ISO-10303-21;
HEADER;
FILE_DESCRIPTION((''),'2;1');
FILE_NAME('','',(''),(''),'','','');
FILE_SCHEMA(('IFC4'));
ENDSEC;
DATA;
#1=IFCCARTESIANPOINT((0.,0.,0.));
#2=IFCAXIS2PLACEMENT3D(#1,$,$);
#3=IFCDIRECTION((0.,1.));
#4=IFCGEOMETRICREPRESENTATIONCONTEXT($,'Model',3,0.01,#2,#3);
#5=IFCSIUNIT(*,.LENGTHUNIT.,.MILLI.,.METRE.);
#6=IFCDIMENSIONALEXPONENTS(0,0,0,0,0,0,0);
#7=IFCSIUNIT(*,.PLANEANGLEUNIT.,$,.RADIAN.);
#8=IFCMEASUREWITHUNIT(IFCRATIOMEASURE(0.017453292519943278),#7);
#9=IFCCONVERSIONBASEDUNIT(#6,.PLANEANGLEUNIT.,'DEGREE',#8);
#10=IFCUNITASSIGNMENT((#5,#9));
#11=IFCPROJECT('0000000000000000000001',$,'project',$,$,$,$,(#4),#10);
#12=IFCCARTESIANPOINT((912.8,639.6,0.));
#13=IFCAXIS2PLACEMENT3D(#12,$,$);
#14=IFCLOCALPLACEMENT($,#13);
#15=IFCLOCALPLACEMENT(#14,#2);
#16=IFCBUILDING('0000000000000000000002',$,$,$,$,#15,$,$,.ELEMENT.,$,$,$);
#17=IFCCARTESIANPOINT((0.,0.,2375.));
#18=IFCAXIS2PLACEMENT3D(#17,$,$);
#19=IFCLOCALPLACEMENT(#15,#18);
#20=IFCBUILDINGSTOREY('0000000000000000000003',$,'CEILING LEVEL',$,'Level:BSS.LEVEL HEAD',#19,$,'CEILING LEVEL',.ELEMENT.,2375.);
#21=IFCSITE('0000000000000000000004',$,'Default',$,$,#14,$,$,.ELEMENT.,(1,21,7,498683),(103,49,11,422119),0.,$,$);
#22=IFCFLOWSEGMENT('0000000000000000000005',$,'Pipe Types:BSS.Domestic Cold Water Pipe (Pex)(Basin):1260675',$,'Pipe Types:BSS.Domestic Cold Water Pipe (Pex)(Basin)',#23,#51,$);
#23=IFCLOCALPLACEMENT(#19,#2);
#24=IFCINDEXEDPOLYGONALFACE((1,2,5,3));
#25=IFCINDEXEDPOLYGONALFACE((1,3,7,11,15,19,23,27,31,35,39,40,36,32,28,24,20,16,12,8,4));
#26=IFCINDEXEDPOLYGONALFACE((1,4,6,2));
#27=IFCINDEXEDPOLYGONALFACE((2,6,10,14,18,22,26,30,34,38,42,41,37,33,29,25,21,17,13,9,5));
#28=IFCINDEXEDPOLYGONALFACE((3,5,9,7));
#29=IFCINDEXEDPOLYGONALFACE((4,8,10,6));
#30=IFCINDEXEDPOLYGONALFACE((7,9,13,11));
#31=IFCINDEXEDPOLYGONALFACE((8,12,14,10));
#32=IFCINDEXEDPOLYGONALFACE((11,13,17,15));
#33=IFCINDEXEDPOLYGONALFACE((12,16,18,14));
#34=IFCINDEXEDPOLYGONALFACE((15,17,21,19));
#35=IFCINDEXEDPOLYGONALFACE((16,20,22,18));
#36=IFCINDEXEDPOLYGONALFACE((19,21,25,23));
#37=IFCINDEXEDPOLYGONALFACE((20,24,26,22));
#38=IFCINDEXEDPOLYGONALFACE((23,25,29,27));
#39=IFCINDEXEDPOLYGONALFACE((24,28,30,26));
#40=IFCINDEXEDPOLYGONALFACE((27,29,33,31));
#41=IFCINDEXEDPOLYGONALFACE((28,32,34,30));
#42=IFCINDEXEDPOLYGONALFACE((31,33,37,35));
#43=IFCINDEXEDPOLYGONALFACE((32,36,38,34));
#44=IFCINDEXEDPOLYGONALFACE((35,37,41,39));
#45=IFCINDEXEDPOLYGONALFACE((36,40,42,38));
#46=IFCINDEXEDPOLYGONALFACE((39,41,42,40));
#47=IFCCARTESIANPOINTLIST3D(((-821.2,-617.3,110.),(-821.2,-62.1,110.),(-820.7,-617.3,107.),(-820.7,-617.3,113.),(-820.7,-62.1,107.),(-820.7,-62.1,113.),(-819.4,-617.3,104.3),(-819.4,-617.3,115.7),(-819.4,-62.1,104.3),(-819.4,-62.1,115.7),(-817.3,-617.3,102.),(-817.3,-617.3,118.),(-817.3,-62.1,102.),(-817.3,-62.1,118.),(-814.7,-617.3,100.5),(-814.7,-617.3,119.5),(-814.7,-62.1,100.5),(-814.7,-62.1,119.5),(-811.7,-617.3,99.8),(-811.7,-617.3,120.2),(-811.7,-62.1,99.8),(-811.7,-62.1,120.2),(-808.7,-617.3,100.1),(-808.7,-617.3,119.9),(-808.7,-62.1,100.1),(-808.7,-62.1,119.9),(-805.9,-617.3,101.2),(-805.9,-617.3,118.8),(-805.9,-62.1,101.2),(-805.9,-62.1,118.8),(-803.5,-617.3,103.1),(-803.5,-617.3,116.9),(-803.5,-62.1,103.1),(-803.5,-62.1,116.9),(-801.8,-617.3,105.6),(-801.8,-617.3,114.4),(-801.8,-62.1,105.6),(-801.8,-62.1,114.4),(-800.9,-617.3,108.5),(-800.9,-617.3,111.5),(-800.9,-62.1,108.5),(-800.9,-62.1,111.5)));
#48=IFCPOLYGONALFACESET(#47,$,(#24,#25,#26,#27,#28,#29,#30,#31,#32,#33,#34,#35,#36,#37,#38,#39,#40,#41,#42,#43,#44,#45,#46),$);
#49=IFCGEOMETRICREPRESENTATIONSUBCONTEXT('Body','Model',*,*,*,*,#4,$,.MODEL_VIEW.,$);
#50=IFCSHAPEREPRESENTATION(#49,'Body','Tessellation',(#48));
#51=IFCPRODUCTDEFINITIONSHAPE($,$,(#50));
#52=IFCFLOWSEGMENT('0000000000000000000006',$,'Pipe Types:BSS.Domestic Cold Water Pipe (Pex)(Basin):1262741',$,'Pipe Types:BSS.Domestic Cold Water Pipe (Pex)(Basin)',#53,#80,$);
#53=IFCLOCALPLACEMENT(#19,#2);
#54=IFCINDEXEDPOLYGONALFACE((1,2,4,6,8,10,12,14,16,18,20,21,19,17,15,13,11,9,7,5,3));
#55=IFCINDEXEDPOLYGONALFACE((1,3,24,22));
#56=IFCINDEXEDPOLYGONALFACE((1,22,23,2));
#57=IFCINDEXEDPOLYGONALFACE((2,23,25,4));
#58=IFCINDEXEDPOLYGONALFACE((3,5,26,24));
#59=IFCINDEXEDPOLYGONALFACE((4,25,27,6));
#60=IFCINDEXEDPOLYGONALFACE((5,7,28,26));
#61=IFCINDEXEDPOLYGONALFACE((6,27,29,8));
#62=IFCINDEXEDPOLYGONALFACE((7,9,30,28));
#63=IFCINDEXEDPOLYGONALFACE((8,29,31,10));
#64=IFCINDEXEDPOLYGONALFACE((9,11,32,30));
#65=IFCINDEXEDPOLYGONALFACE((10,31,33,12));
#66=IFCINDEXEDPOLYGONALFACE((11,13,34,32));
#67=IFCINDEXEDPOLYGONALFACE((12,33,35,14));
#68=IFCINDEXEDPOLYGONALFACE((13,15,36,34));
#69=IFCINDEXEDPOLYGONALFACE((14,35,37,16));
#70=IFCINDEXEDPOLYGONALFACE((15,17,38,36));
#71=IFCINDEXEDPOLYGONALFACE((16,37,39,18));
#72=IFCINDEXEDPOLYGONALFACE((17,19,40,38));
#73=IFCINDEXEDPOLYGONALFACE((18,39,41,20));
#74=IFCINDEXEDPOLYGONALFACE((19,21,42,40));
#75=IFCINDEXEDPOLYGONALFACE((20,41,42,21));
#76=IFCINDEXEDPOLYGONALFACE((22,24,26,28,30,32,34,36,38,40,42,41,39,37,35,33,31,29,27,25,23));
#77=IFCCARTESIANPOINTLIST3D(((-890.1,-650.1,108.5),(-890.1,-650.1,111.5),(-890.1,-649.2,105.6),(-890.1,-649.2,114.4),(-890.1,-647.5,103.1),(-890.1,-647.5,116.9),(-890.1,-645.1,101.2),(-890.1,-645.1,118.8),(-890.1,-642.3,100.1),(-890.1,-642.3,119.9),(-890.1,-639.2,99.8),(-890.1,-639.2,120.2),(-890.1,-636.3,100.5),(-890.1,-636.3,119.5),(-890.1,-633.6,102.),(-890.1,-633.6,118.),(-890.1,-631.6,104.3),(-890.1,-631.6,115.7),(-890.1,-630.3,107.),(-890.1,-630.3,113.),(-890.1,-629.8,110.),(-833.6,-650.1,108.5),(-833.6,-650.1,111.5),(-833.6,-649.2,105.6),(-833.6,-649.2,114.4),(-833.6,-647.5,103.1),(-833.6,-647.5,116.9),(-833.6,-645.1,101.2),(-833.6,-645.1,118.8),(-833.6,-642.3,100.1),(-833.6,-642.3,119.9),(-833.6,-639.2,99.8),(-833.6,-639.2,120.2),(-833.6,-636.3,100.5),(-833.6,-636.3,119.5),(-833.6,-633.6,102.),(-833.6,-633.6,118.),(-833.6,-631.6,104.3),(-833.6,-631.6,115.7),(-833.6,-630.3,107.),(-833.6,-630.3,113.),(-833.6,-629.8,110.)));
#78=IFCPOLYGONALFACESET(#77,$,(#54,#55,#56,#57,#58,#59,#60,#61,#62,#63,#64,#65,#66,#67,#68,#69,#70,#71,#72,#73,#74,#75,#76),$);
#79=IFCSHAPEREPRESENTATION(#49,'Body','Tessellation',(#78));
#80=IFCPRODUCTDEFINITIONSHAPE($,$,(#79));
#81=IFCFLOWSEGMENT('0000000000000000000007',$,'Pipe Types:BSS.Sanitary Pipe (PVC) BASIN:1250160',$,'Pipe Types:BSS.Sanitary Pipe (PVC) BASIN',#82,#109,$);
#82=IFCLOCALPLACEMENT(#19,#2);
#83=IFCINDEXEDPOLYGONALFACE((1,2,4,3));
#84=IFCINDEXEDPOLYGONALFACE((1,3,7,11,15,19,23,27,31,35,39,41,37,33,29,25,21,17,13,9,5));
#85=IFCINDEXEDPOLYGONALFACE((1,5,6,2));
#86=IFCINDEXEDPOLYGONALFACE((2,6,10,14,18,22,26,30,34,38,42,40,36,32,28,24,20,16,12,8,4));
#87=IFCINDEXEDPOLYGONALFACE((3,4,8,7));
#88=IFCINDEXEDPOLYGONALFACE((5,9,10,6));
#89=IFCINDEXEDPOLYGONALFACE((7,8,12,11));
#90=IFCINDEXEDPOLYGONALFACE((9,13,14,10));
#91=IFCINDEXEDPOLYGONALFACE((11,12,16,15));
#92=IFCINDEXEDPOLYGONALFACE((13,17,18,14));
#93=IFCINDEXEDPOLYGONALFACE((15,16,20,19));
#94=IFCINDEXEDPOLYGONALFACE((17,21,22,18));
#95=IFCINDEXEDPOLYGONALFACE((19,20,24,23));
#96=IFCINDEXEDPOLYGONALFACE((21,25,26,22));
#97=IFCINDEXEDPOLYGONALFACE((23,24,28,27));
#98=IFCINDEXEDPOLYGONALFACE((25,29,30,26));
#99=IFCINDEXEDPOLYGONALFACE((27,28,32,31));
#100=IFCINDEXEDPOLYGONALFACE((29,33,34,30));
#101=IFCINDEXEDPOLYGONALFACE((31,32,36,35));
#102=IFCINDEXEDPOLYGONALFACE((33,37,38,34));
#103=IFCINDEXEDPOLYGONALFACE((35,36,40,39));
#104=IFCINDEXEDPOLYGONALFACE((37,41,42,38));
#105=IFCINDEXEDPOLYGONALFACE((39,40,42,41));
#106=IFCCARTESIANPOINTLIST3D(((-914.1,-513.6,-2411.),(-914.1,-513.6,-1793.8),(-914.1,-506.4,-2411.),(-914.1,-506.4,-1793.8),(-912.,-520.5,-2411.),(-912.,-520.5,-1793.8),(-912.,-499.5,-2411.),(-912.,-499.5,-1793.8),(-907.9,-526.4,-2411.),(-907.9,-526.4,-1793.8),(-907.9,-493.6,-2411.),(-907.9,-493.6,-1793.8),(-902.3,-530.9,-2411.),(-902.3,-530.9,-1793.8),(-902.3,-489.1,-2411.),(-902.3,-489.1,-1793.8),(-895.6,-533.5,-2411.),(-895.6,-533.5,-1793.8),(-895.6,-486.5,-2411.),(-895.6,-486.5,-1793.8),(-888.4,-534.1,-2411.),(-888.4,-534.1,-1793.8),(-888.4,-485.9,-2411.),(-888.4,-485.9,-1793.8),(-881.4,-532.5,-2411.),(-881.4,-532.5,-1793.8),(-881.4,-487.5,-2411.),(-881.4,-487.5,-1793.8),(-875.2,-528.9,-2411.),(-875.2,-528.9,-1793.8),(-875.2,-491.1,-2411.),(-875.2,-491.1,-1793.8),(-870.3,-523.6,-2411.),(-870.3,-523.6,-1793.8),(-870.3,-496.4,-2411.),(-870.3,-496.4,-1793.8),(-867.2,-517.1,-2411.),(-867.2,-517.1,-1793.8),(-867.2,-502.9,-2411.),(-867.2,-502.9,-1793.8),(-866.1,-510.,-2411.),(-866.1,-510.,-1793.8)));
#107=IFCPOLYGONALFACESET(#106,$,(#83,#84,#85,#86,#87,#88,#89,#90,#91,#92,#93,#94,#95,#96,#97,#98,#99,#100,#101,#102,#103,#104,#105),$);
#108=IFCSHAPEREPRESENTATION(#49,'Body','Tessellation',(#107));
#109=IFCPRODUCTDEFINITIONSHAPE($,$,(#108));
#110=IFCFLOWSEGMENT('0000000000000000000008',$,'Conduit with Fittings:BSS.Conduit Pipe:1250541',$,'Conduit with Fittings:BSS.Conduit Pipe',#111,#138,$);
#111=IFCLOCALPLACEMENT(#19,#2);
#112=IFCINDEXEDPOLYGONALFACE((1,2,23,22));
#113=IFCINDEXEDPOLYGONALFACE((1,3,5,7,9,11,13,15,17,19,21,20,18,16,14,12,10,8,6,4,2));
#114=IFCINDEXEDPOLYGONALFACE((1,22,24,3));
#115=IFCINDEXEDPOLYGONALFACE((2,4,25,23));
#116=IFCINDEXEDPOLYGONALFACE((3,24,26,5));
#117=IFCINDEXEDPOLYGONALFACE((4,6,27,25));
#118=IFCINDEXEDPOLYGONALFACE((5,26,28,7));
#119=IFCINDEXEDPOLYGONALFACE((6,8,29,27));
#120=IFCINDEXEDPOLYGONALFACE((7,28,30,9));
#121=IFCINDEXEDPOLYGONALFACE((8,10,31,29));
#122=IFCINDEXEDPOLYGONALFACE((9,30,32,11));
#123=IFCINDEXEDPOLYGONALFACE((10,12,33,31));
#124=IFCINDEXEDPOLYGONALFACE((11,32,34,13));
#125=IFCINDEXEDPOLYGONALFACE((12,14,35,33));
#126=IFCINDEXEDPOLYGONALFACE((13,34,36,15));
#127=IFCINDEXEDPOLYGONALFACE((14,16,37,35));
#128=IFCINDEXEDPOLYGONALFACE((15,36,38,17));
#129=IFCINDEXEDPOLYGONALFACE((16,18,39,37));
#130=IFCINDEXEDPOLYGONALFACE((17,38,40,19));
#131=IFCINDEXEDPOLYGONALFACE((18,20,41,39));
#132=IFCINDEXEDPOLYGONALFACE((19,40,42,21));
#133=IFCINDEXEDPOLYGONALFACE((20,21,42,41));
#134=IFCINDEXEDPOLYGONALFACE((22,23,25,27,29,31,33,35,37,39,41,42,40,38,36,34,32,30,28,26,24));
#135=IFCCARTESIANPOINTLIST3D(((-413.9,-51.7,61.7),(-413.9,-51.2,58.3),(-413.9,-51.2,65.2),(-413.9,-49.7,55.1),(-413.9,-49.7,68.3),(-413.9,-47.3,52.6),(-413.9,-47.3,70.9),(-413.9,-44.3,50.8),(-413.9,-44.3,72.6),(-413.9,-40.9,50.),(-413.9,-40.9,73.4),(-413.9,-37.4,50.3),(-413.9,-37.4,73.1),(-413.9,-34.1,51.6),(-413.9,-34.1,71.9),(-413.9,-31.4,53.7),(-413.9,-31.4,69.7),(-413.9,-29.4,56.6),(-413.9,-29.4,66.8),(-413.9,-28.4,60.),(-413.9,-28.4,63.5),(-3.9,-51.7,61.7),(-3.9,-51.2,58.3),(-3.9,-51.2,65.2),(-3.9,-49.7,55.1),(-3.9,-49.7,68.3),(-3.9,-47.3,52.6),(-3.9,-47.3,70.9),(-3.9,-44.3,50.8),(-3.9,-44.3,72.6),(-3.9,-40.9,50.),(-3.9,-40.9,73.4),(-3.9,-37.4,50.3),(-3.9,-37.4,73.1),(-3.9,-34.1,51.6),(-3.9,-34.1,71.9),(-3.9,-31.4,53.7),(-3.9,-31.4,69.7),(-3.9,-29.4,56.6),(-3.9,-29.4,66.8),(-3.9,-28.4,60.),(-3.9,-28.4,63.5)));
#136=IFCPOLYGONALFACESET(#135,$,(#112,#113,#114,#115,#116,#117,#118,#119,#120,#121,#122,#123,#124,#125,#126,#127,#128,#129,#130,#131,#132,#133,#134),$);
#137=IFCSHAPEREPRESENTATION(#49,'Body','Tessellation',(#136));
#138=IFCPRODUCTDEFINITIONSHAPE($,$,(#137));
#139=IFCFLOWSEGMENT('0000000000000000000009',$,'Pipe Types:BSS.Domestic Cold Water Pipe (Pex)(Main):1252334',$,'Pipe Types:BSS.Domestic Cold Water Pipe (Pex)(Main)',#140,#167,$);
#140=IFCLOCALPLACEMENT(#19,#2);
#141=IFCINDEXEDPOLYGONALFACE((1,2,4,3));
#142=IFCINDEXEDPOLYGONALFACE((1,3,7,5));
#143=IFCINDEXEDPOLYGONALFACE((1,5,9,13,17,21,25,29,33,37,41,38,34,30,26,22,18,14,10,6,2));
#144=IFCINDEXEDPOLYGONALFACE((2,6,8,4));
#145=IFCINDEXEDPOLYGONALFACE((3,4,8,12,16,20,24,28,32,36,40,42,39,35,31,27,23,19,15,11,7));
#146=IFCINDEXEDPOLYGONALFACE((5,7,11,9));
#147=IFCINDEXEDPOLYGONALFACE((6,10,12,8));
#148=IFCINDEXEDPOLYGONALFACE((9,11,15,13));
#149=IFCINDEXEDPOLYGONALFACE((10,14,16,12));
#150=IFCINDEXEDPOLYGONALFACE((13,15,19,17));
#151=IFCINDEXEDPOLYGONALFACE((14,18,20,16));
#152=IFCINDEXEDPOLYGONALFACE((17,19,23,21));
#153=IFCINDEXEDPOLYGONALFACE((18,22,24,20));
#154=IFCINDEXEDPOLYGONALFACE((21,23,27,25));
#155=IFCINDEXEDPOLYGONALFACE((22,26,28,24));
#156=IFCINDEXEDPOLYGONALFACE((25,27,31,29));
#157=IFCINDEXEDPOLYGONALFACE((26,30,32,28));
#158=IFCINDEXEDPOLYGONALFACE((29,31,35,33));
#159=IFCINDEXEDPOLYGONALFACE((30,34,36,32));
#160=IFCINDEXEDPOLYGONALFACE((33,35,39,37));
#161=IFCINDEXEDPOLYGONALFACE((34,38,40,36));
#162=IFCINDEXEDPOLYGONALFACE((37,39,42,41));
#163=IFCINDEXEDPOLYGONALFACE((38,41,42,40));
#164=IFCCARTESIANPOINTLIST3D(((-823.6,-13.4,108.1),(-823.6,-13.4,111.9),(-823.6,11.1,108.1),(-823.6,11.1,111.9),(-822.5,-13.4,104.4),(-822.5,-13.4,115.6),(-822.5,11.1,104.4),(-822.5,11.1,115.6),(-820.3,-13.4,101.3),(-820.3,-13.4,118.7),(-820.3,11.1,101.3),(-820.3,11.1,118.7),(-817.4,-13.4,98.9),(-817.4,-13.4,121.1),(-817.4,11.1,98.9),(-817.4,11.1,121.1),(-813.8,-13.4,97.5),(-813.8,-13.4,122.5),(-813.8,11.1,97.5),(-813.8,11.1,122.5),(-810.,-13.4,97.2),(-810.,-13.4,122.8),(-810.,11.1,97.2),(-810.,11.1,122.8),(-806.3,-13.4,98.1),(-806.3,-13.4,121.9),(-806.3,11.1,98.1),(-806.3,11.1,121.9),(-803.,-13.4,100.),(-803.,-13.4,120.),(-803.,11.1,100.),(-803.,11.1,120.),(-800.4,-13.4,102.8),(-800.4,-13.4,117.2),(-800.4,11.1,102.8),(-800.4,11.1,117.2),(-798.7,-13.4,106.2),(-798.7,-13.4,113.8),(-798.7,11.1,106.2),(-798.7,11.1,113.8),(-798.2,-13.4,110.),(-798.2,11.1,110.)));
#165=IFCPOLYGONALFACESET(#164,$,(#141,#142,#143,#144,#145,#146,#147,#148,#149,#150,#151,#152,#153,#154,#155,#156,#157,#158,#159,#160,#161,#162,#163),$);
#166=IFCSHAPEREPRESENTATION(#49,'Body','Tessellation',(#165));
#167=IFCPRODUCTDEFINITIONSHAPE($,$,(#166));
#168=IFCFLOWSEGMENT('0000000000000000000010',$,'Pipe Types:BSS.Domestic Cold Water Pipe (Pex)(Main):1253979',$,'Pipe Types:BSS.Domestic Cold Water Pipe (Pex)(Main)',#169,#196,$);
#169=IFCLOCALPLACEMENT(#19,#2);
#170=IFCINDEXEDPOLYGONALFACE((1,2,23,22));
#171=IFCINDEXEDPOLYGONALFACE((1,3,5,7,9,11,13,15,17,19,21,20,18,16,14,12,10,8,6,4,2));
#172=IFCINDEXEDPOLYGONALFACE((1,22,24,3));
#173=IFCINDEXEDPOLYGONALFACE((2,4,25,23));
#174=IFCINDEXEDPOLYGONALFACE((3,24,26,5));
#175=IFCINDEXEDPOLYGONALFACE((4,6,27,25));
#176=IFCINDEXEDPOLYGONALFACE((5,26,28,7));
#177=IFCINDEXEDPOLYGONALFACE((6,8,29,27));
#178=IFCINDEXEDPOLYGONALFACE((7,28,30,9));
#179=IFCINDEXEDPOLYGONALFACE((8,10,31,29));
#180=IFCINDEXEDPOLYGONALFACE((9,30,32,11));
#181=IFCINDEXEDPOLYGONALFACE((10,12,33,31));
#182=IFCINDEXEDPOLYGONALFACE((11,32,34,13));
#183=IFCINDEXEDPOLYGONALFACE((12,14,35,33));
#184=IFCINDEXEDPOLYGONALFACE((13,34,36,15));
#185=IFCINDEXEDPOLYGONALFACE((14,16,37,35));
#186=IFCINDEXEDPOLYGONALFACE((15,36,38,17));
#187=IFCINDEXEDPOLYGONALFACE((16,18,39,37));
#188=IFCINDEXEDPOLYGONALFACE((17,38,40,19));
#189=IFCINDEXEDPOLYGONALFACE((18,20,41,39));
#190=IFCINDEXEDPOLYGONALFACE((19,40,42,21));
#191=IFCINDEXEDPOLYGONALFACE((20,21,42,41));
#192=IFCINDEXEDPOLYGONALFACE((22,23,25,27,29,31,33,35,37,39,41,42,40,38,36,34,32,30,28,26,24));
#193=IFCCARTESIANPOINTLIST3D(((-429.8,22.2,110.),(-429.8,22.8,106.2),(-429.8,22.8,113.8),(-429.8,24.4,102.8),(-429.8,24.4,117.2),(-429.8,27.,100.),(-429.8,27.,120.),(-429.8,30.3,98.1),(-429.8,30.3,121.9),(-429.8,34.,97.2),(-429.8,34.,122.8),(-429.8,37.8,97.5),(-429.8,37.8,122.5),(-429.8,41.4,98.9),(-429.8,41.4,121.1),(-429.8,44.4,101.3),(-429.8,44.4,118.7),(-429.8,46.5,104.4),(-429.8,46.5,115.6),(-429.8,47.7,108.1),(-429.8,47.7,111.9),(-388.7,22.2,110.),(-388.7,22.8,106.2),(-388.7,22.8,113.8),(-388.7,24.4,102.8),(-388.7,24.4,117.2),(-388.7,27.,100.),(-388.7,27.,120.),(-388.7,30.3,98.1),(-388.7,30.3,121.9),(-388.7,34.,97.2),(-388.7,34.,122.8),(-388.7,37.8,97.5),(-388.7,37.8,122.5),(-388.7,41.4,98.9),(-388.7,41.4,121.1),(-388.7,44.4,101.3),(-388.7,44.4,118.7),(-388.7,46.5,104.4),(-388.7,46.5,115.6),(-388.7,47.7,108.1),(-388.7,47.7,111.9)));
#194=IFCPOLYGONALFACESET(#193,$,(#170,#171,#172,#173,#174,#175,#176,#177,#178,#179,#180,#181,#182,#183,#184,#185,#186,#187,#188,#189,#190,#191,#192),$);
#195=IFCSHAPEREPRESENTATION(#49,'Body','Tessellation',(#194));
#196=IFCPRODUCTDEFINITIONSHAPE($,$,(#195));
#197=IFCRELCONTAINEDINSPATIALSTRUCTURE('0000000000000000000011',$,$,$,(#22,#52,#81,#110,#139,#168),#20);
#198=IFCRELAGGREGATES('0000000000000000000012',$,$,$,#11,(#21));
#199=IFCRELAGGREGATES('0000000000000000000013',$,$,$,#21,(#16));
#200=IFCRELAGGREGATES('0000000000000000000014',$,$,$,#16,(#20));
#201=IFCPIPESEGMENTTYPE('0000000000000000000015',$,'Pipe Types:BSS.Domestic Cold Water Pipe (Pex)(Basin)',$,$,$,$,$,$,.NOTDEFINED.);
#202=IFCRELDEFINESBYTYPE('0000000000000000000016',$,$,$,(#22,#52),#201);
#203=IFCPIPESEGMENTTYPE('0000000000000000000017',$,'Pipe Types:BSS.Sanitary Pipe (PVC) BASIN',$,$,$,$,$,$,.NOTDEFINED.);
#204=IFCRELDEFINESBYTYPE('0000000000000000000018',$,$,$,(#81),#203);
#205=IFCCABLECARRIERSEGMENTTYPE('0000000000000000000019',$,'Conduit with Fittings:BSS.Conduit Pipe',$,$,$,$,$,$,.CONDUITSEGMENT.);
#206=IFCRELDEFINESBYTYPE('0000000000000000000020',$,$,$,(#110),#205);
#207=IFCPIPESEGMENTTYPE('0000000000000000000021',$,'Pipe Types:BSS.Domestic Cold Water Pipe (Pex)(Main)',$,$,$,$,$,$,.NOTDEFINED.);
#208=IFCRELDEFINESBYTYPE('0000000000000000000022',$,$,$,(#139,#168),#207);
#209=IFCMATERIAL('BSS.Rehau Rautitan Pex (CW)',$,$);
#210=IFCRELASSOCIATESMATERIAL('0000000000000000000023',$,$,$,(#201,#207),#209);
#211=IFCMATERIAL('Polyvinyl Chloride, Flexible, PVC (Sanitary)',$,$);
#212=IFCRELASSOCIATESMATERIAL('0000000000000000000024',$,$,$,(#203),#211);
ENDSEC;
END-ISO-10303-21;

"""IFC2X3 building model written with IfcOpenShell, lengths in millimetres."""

from ifc_helpers import new_model, entity, si_unit, converted_unit, direction, frame, frame_2d, origin, origin_2d_with_axis, place, context, subcontext, project, spatial, circle, extrude, material, type_object, element, save


model = new_model("IFC2X3")

# Units and contexts
model_context = context("Model", 3, precision=0.01, world=origin(), true_north=direction((0.0, 1.0)))
body_context = subcontext(model_context, "Body", "Model", "MODEL_VIEW")
ifc_project = project(units=[si_unit("LENGTHUNIT", "METRE", prefix="MILLI"), converted_unit("PLANEANGLEUNIT", "DEGREE", entity("IfcRatioMeasure", 0.017453292519943278), si_unit("PLANEANGLEUNIT", "RADIAN"), dimensions=[0, 0, 0, 0, 0, 0, 0])], contexts=[model_context])

# Site, building, storey
site_placement = place(None, frame((912.8, 639.6, 0.0)))
site = spatial("IfcSite", under=ifc_project, at=site_placement, Name="Default", CompositionType="ELEMENT", RefLatitude=(1, 21, 7, 498683), RefLongitude=(103, 49, 11, 422119), RefElevation=0.0)
building_placement = place(site_placement, origin())
building = spatial("IfcBuilding", under=site, at=building_placement, CompositionType="ELEMENT")
storey_placement = place(building_placement, frame((0.0, 0.0, 2375.0)))
storey = spatial("IfcBuildingStorey", under=building, at=storey_placement, Name="CEILING LEVEL", ObjectType="Level:BSS.LEVEL HEAD", LongName="CEILING LEVEL", CompositionType="ELEMENT", Elevation=2375.0)

# Flow segments
ifc_material_1 = material(Name="BSS.Rehau Rautitan Pex (CW)")
pipe_segment_type_1 = type_object("IfcPipeSegmentType", Name="Pipe Types:BSS.Domestic Cold Water Pipe (Pex)(Basin)", PredefinedType="NOTDEFINED", material=ifc_material_1)
flow_segment_1_placement = place(storey_placement, origin())
element("IfcFlowSegment", 1, at=flow_segment_1_placement, inside=storey, type_object=pipe_segment_type_1, Name="Pipe Types:BSS.Domestic Cold Water Pipe (Pex)(Basin):1260675", ObjectType="Pipe Types:BSS.Domestic Cold Water Pipe (Pex)(Basin)", context=body_context, shape_type="SweptSolid", body=[
    extrude(circle(Radius=10.2, at=frame_2d((0.0, 0.0), x_axis=(1.0, 0.0))), frame((-811.0, -617.3, 110.0), z_axis=(0.0, 1.0, 0.0), x_axis=(-1.0, 0.0, 0.0)), (0.0, 0.0, 1.0), 555.2),
])
flow_segment_2_placement = place(storey_placement, origin())
element("IfcFlowSegment", 2, at=flow_segment_2_placement, inside=storey, type_object=pipe_segment_type_1, Name="Pipe Types:BSS.Domestic Cold Water Pipe (Pex)(Basin):1262741", ObjectType="Pipe Types:BSS.Domestic Cold Water Pipe (Pex)(Basin)", context=body_context, shape_type="SweptSolid", body=[
    extrude(circle(Radius=10.2, at=origin_2d_with_axis()), frame((-890.1, -640.0, 110.0), z_axis=(1.0, 0.0, 0.0), x_axis=(0.0, 1.0, 0.0)), (0.0, 0.0, 1.0), 56.5),
])
ifc_material_2 = material(Name="Polyvinyl Chloride, Flexible, PVC (Sanitary)")
pipe_segment_type_2 = type_object("IfcPipeSegmentType", Name="Pipe Types:BSS.Sanitary Pipe (PVC) BASIN", PredefinedType="NOTDEFINED", material=ifc_material_2)
flow_segment_3_placement = place(storey_placement, origin())
element("IfcFlowSegment", 3, at=flow_segment_3_placement, inside=storey, type_object=pipe_segment_type_2, Name="Pipe Types:BSS.Sanitary Pipe (PVC) BASIN:1250160", ObjectType="Pipe Types:BSS.Sanitary Pipe (PVC) BASIN", context=body_context, shape_type="SweptSolid", body=[
    extrude(circle(Radius=24.1, at=frame_2d((0.0, 0.0), x_axis=(1.0, 0.0))), frame((-890.2, -510.0, -2411.0)), (0.0, 0.0, 1.0), 617.2),
])
cable_carrier_segment_type = type_object("IfcCableCarrierSegmentType", Name="Conduit with Fittings:BSS.Conduit Pipe", PredefinedType="CONDUITSEGMENT")
flow_segment_4_placement = place(storey_placement, origin())
element("IfcFlowSegment", 4, at=flow_segment_4_placement, inside=storey, type_object=cable_carrier_segment_type, Name="Conduit with Fittings:BSS.Conduit Pipe:1250541", ObjectType="Conduit with Fittings:BSS.Conduit Pipe", context=body_context, shape_type="SweptSolid", body=[
    extrude(circle(Radius=11.7, at=frame_2d((0.0, 0.0), x_axis=(1.0, 0.0))), frame((-413.9, -40.0, 61.7), z_axis=(1.0, 0.0, 0.0), x_axis=(0.0, -1.0, 0.0)), (0.0, 0.0, 1.0), 410.0),
])
pipe_segment_type_3 = type_object("IfcPipeSegmentType", Name="Pipe Types:BSS.Domestic Cold Water Pipe (Pex)(Main)", PredefinedType="NOTDEFINED", material=ifc_material_1)
flow_segment_5_placement = place(storey_placement, origin())
element("IfcFlowSegment", 5, at=flow_segment_5_placement, inside=storey, type_object=pipe_segment_type_3, Name="Pipe Types:BSS.Domestic Cold Water Pipe (Pex)(Main):1252334", ObjectType="Pipe Types:BSS.Domestic Cold Water Pipe (Pex)(Main)", context=body_context, shape_type="SweptSolid", body=[
    extrude(circle(Radius=12.8, at=origin_2d_with_axis()), frame((-811.0, -13.4, 110.0), z_axis=(0.0, 1.0, 0.0), x_axis=(1.0, 0.0, 0.0)), (0.0, 0.0, 1.0), 24.5),
])
flow_segment_6_placement = place(storey_placement, origin())
element("IfcFlowSegment", 6, at=flow_segment_6_placement, inside=storey, type_object=pipe_segment_type_3, Name="Pipe Types:BSS.Domestic Cold Water Pipe (Pex)(Main):1253979", ObjectType="Pipe Types:BSS.Domestic Cold Water Pipe (Pex)(Main)", context=body_context, shape_type="SweptSolid", body=[
    extrude(circle(Radius=12.8, at=frame_2d((0.0, 0.0), x_axis=(1.0, 0.0))), frame((-429.8, 35.0, 110.0), z_axis=(1.0, 0.0, 0.0), x_axis=(0.0, -1.0, 0.0)), (0.0, 0.0, 1.0), 41.1),
])

save(model, "model.ifc")
